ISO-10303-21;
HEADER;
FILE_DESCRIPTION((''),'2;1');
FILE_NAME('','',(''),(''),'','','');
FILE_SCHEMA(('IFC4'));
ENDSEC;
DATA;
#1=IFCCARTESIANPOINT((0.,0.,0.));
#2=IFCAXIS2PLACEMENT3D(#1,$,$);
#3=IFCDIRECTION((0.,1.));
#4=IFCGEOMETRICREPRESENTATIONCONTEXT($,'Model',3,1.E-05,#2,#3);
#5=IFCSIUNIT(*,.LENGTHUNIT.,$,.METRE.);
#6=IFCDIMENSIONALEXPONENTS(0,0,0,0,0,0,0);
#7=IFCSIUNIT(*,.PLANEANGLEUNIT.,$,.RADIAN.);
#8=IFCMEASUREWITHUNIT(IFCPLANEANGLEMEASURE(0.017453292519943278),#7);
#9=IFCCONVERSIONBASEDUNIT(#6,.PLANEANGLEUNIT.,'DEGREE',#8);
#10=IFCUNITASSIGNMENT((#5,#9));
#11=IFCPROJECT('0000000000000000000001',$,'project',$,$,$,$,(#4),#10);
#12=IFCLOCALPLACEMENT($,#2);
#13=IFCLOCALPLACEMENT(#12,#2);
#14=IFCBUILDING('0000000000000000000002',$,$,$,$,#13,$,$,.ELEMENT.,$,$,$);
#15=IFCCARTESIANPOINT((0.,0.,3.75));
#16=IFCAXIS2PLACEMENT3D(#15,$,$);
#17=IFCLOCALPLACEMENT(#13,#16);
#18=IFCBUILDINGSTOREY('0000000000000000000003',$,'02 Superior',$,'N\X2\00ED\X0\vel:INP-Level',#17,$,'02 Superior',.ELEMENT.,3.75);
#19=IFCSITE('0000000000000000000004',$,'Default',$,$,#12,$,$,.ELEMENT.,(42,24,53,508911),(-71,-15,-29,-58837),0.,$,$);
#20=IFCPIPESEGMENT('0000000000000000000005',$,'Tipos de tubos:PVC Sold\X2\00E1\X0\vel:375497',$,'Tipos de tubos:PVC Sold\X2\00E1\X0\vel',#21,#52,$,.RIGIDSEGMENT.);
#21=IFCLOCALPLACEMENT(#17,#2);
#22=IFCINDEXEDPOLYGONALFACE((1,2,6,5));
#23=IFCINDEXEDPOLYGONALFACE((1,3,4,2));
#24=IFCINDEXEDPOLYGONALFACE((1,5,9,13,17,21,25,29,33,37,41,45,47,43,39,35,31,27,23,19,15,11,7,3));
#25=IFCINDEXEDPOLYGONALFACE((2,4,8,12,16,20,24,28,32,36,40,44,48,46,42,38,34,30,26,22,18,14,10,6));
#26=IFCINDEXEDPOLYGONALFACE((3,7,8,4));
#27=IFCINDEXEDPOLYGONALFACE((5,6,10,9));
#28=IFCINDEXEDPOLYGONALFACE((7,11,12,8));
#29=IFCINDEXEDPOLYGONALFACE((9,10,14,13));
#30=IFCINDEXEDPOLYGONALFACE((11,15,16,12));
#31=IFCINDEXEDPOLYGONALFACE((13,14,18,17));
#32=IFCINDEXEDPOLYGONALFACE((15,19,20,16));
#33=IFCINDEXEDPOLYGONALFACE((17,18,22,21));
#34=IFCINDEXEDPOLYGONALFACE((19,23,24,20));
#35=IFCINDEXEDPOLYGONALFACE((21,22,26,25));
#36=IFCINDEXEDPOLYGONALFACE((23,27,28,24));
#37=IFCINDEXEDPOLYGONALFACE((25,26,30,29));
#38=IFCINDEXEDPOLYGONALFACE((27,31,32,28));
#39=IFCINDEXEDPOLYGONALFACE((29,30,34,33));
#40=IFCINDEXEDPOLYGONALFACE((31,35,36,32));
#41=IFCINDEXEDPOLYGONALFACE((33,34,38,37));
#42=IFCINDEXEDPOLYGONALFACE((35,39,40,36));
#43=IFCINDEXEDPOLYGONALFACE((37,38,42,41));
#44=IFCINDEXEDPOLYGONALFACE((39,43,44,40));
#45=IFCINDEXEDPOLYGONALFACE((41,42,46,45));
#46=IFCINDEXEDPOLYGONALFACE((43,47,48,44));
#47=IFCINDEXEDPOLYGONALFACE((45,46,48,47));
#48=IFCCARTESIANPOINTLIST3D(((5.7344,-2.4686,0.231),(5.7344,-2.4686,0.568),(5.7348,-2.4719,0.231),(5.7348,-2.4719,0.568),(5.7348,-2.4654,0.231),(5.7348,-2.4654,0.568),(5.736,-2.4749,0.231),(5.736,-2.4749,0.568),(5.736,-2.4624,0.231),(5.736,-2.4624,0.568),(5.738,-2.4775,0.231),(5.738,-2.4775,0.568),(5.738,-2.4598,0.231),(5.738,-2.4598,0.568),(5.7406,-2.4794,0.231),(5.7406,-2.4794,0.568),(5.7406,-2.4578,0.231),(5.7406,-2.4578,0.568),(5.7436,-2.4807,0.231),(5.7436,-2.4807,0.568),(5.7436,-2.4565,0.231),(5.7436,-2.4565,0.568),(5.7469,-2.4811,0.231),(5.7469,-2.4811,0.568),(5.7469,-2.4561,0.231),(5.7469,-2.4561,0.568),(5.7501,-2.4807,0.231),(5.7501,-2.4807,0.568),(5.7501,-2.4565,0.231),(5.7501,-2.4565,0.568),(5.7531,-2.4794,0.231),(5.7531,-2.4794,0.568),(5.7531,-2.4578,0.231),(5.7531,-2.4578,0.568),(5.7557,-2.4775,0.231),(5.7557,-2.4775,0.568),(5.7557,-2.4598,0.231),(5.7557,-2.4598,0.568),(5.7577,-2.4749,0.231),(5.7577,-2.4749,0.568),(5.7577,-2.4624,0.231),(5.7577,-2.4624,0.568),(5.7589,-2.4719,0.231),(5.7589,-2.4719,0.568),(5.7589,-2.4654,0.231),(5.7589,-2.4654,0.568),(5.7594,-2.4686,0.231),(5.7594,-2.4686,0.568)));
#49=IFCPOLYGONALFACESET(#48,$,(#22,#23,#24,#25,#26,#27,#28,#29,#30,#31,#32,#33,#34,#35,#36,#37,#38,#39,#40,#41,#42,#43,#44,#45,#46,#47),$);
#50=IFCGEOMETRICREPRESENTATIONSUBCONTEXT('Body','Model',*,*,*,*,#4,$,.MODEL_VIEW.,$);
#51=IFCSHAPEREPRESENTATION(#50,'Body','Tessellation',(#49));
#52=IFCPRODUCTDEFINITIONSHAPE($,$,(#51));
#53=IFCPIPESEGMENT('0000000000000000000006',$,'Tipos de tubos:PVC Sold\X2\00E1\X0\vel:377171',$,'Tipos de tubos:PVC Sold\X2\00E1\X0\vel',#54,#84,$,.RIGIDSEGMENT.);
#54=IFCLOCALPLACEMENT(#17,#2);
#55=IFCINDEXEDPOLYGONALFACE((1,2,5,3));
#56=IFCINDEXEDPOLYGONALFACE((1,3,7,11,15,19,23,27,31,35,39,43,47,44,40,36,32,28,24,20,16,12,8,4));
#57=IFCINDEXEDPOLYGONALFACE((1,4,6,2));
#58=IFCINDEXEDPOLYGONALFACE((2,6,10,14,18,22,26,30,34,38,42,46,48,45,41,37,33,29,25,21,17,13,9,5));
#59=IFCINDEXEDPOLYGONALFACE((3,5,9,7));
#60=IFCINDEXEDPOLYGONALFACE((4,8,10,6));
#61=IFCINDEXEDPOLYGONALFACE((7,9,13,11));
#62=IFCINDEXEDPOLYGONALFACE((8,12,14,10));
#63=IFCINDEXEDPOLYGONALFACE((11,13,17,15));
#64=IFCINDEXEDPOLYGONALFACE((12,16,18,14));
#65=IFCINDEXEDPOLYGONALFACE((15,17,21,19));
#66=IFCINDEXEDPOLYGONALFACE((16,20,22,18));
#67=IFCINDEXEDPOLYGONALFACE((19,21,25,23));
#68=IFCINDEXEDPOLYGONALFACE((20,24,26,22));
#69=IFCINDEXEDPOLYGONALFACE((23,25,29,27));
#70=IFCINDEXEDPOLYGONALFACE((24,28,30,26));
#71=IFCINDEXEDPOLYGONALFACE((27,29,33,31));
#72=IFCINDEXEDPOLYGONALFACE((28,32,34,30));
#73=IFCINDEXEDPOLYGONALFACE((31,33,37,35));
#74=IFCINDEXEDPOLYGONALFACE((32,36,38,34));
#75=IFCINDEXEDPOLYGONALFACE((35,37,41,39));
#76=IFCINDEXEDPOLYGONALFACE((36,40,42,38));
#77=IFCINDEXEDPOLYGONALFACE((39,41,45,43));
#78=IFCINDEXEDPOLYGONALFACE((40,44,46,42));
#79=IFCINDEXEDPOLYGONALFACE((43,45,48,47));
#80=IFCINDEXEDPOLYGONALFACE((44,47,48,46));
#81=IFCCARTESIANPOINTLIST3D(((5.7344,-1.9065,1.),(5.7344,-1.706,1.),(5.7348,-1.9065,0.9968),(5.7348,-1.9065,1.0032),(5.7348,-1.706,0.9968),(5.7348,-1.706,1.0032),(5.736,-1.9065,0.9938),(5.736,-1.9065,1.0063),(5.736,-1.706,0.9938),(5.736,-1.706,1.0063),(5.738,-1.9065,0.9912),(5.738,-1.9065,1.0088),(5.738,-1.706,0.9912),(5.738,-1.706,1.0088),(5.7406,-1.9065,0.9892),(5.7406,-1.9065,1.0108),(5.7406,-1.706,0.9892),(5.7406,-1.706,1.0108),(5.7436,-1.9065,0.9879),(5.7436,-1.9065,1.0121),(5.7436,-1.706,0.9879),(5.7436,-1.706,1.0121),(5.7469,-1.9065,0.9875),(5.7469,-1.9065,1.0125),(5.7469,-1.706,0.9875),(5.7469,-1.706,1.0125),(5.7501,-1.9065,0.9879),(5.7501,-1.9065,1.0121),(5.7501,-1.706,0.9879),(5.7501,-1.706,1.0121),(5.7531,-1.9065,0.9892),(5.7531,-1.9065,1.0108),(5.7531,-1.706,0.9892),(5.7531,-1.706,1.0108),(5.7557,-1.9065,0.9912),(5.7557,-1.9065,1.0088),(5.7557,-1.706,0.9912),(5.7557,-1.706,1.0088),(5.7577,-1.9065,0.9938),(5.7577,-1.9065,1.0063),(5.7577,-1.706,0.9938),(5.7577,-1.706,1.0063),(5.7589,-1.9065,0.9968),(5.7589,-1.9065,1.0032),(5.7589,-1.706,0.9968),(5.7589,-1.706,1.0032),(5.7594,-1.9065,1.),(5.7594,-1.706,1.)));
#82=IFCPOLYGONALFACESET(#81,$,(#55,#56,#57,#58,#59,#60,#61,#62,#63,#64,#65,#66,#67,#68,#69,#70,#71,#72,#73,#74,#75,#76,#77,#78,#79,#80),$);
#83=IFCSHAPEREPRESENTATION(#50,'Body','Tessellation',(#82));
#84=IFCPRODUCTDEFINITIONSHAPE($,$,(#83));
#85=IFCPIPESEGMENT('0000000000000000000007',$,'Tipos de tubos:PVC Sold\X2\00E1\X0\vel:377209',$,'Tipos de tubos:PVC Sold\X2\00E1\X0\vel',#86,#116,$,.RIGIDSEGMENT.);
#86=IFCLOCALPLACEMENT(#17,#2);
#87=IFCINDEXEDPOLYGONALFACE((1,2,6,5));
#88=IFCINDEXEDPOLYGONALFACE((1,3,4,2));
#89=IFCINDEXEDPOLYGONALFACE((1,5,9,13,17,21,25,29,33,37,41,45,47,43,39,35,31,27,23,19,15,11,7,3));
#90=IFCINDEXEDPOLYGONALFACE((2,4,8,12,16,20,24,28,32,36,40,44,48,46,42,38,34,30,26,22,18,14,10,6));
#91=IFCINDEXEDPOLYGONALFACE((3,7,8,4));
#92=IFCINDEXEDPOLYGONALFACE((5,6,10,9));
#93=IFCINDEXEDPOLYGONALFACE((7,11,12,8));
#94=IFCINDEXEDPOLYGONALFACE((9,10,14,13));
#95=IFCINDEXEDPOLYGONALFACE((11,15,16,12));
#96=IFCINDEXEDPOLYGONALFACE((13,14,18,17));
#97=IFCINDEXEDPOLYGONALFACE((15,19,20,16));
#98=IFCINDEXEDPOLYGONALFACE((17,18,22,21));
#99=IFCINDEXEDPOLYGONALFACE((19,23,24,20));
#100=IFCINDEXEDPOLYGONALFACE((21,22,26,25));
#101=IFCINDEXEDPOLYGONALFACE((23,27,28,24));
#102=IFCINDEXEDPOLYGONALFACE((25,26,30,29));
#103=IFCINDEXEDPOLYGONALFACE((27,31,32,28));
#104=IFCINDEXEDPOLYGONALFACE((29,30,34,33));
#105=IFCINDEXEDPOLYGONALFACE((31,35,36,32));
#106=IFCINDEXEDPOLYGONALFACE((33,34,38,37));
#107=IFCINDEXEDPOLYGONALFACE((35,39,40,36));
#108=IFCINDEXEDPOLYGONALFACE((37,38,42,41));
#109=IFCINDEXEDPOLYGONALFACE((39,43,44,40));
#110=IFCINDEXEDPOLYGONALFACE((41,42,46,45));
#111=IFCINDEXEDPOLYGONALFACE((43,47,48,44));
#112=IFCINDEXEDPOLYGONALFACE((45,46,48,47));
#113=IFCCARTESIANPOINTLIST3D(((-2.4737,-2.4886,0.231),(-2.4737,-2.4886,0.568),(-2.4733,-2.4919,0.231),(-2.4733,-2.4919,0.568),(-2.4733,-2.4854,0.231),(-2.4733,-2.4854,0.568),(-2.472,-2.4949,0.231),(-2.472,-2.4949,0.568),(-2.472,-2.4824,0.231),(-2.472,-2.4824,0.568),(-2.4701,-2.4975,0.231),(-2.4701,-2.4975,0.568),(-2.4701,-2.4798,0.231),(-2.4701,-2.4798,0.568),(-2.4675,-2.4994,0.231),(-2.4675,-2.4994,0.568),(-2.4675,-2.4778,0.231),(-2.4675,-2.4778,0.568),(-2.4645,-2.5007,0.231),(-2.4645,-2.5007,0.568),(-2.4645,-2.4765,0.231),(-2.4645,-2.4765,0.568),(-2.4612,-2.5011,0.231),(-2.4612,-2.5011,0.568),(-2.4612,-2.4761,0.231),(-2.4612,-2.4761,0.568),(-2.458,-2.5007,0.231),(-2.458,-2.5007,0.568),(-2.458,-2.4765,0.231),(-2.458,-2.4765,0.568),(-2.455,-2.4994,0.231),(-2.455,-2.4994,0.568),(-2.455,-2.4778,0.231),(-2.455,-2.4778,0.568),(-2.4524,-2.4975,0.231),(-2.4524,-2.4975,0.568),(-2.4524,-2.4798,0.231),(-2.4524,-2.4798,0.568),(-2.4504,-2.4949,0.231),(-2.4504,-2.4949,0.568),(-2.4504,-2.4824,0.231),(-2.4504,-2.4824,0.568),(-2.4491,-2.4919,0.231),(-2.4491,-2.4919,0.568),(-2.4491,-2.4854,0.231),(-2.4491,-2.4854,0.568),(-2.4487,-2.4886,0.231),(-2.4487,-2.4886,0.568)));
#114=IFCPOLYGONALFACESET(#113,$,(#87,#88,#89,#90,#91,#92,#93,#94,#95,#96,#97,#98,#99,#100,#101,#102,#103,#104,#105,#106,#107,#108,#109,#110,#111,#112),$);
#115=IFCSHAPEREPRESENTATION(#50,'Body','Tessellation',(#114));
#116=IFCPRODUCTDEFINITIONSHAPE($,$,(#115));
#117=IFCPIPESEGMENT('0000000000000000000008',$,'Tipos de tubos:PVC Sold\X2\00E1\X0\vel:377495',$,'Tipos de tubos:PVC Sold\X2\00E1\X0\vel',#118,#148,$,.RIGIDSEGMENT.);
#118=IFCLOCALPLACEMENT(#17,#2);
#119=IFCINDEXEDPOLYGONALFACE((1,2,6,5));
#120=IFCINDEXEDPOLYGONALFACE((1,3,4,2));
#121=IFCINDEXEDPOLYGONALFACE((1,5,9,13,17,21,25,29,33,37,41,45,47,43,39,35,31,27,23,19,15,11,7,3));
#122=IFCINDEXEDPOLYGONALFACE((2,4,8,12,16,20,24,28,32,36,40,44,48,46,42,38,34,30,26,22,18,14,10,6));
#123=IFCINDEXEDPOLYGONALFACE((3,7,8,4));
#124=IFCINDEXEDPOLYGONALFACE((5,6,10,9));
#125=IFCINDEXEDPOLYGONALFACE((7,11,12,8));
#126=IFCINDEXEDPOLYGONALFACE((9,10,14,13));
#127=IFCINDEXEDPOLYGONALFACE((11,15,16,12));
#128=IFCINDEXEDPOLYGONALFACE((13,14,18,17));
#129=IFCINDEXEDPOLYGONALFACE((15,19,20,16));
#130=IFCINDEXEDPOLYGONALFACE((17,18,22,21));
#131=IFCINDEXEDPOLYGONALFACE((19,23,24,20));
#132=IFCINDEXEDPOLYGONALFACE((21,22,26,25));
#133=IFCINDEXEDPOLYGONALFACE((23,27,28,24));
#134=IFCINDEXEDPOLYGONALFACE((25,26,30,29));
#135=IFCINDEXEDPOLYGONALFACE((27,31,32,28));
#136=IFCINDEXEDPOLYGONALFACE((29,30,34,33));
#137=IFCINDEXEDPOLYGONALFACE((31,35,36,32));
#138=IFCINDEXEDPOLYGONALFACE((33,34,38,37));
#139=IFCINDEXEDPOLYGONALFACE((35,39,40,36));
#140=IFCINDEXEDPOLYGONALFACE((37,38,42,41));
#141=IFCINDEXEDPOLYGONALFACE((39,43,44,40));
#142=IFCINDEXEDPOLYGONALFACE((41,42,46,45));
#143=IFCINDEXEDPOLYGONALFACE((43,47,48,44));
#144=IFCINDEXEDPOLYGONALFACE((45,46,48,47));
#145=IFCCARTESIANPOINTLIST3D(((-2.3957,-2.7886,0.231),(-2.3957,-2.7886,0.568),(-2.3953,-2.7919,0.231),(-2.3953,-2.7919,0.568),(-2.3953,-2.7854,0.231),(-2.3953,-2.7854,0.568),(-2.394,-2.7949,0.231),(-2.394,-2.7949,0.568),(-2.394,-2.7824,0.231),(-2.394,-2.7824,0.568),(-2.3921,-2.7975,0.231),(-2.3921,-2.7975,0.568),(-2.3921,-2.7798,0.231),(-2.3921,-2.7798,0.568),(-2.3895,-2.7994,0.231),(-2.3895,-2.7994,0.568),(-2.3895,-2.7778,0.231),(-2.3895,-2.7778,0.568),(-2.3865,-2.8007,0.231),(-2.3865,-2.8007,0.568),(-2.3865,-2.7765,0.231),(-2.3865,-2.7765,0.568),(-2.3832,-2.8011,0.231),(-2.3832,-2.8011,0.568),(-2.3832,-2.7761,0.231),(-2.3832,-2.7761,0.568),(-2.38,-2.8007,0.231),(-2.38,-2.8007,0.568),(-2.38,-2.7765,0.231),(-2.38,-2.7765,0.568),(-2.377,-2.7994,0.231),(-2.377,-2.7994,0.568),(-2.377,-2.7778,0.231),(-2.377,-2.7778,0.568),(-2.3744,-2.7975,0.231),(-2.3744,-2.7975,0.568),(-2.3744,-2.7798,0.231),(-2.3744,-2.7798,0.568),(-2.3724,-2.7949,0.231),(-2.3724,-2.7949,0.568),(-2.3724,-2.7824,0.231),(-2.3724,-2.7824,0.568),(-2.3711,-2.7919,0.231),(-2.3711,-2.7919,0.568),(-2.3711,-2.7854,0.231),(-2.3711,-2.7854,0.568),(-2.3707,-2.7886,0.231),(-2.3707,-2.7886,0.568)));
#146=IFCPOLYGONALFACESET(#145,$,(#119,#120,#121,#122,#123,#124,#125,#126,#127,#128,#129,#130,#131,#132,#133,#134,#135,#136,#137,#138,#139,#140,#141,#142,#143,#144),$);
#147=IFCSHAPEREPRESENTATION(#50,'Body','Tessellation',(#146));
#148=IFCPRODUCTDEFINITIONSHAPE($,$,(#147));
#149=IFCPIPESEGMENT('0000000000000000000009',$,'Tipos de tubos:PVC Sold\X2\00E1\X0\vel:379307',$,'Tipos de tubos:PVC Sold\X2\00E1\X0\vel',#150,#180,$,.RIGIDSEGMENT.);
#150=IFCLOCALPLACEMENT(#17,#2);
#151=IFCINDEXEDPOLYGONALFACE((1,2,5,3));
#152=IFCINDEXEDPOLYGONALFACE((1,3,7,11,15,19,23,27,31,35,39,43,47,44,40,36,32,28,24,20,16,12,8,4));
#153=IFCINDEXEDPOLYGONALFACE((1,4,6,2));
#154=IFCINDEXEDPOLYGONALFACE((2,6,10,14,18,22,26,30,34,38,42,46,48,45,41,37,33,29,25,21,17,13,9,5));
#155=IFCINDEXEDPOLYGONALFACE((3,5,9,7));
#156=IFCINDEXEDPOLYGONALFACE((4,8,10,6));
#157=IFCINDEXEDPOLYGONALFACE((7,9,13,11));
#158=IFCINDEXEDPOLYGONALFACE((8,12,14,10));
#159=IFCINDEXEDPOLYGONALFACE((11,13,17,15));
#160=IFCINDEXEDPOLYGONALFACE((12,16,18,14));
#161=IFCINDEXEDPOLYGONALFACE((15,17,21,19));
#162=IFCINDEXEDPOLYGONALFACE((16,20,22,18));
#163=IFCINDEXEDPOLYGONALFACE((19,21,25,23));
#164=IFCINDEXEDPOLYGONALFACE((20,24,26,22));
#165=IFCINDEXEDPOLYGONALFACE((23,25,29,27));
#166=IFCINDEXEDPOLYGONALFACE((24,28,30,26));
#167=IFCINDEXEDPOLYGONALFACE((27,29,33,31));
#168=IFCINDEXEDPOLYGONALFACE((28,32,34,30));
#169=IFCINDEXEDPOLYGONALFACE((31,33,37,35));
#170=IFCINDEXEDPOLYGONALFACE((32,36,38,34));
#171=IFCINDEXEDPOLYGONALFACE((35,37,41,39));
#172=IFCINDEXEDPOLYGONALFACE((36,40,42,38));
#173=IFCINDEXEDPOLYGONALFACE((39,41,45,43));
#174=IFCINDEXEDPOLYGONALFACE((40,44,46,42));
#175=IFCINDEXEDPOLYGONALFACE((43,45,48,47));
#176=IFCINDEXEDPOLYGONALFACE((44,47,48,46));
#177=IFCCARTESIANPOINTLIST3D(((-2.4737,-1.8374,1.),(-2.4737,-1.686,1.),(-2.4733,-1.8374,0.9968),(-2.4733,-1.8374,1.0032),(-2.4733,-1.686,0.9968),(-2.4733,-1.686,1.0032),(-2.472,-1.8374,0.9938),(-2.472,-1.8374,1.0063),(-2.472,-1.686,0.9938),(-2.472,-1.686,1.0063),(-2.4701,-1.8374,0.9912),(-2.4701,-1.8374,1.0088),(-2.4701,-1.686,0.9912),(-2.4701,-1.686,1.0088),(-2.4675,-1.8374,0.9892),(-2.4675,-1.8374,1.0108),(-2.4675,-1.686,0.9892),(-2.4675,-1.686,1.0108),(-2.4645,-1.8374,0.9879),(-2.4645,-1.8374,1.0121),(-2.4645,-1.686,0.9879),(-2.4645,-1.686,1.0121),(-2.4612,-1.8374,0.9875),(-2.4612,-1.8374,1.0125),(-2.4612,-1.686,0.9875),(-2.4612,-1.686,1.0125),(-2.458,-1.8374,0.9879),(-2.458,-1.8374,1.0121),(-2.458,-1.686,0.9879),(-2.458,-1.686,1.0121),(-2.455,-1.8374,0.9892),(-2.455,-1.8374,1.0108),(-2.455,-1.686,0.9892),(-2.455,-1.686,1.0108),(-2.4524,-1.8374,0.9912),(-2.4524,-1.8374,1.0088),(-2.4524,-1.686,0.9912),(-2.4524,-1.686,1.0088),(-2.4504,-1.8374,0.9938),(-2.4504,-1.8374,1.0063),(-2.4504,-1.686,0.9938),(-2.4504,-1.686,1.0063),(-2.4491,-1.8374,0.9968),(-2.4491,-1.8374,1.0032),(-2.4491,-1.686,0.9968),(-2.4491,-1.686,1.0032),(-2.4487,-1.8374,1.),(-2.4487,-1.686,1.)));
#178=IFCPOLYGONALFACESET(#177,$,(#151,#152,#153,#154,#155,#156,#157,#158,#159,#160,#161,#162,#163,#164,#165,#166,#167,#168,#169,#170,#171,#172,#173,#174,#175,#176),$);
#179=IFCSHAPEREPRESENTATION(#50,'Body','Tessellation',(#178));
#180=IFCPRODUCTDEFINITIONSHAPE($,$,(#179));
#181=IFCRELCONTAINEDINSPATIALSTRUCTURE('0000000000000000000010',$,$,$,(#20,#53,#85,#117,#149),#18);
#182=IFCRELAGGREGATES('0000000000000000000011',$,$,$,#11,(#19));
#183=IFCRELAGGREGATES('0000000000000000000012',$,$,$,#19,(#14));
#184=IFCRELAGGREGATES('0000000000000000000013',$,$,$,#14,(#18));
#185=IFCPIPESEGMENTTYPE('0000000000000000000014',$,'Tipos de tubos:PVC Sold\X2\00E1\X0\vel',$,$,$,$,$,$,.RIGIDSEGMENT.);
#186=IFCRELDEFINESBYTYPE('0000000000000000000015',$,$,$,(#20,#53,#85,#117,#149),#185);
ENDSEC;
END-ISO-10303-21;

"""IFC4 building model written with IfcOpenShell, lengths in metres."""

from ifc_helpers import new_model, entity, si_unit, converted_unit, direction, frame, origin, place, context, subcontext, project, spatial, arc, indexed_curve, outline, extrude, type_object, element, save


model = new_model("IFC4")

# Units and contexts
model_context = context("Model", 3, precision=1e-05, world=origin(), true_north=direction((0.0, 1.0)))
body_context = subcontext(model_context, "Body", "Model", "MODEL_VIEW")
ifc_project = project(units=[si_unit("LENGTHUNIT", "METRE"), converted_unit("PLANEANGLEUNIT", "DEGREE", entity("IfcPlaneAngleMeasure", 0.017453292519943278), si_unit("PLANEANGLEUNIT", "RADIAN"), dimensions=[0, 0, 0, 0, 0, 0, 0])], contexts=[model_context])

# Site, building, storey
site_placement = place(None, origin())
site = spatial("IfcSite", under=ifc_project, at=site_placement, Name="Default", CompositionType="ELEMENT", RefLatitude=(42, 24, 53, 508911), RefLongitude=(-71, -15, -29, -58837), RefElevation=0.0)
building_placement = place(site_placement, origin())
building = spatial("IfcBuilding", under=site, at=building_placement, CompositionType="ELEMENT")
storey_placement = place(building_placement, frame((0.0, 0.0, 3.75)))
storey = spatial("IfcBuildingStorey", under=building, at=storey_placement, Name="02 Superior", ObjectType="Nível:INP-Level", LongName="02 Superior", CompositionType="ELEMENT", Elevation=3.75)

# Pipe segments
pipe_segment_type = type_object("IfcPipeSegmentType", Name="Tipos de tubos:PVC Soldável", PredefinedType="RIGIDSEGMENT")
pipe_segment_1_placement = place(storey_placement, origin())
element("IfcPipeSegment", 1, at=pipe_segment_1_placement, inside=storey, type_object=pipe_segment_type, Name="Tipos de tubos:PVC Soldável:375497", ObjectType="Tipos de tubos:PVC Soldável", PredefinedType="RIGIDSEGMENT", context=body_context, shape_type="SweptSolid", body=[
    extrude(outline(indexed_curve([(0.0125, 0.0), (0.0088, 0.0088), (0.0, 0.0125), (-0.0088, 0.0088), (-0.0125, 0.0), (-0.0088, -0.0088), (0.0, -0.0125), (0.0088, -0.0088)], segments=[arc(1, 2, 3), arc(3, 4, 5), arc(5, 6, 7), arc(7, 8, 1)], self_intersect=False)), frame((5.7469, -2.4686, 0.231)), (0.0, 0.0, 1.0), 0.337),
])
pipe_segment_2_placement = place(storey_placement, origin())
element("IfcPipeSegment", 2, at=pipe_segment_2_placement, inside=storey, type_object=pipe_segment_type, Name="Tipos de tubos:PVC Soldável:377171", ObjectType="Tipos de tubos:PVC Soldável", PredefinedType="RIGIDSEGMENT", context=body_context, shape_type="SweptSolid", body=[
    extrude(outline(indexed_curve([(0.0125, 0.0), (0.0088, 0.0088), (0.0, 0.0125), (-0.0088, 0.0088), (-0.0125, 0.0), (-0.0088, -0.0088), (0.0, -0.0125), (0.0088, -0.0088)], segments=[arc(1, 2, 3), arc(3, 4, 5), arc(5, 6, 7), arc(7, 8, 1)], self_intersect=False)), frame((5.7469, -1.9065, 1.0), z_axis=(0.0, 1.0, 0.0), x_axis=(1.0, 0.0, 0.0)), (0.0, 0.0, 1.0), 0.2005),
])
pipe_segment_3_placement = place(storey_placement, origin())
element("IfcPipeSegment", 3, at=pipe_segment_3_placement, inside=storey, type_object=pipe_segment_type, Name="Tipos de tubos:PVC Soldável:377209", ObjectType="Tipos de tubos:PVC Soldável", PredefinedType="RIGIDSEGMENT", context=body_context, shape_type="SweptSolid", body=[
    extrude(outline(indexed_curve([(0.0125, 0.0), (0.0088, 0.0088), (0.0, 0.0125), (-0.0088, 0.0088), (-0.0125, 0.0), (-0.0088, -0.0088), (0.0, -0.0125), (0.0088, -0.0088)], segments=[arc(1, 2, 3), arc(3, 4, 5), arc(5, 6, 7), arc(7, 8, 1)], self_intersect=False)), frame((-2.4612, -2.4886, 0.231)), (0.0, 0.0, 1.0), 0.337),
])
pipe_segment_4_placement = place(storey_placement, origin())
element("IfcPipeSegment", 4, at=pipe_segment_4_placement, inside=storey, type_object=pipe_segment_type, Name="Tipos de tubos:PVC Soldável:377495", ObjectType="Tipos de tubos:PVC Soldável", PredefinedType="RIGIDSEGMENT", context=body_context, shape_type="SweptSolid", body=[
    extrude(outline(indexed_curve([(0.0125, 0.0), (0.0088, 0.0088), (0.0, 0.0125), (-0.0088, 0.0088), (-0.0125, 0.0), (-0.0088, -0.0088), (0.0, -0.0125), (0.0088, -0.0088)], segments=[arc(1, 2, 3), arc(3, 4, 5), arc(5, 6, 7), arc(7, 8, 1)], self_intersect=False)), frame((-2.3832, -2.7886, 0.231)), (0.0, 0.0, 1.0), 0.337),
])
pipe_segment_5_placement = place(storey_placement, origin())
element("IfcPipeSegment", 5, at=pipe_segment_5_placement, inside=storey, type_object=pipe_segment_type, Name="Tipos de tubos:PVC Soldável:379307", ObjectType="Tipos de tubos:PVC Soldável", PredefinedType="RIGIDSEGMENT", context=body_context, shape_type="SweptSolid", body=[
    extrude(outline(indexed_curve([(0.0125, 0.0), (0.0088, 0.0088), (0.0, 0.0125), (-0.0088, 0.0088), (-0.0125, 0.0), (-0.0088, -0.0088), (0.0, -0.0125), (0.0088, -0.0088)], segments=[arc(1, 2, 3), arc(3, 4, 5), arc(5, 6, 7), arc(7, 8, 1)], self_intersect=False)), frame((-2.4612, -1.8374, 1.0), z_axis=(0.0, 1.0, 0.0), x_axis=(1.0, 0.0, 0.0)), (0.0, 0.0, 1.0), 0.1514),
])

save(model, "model.ifc")
